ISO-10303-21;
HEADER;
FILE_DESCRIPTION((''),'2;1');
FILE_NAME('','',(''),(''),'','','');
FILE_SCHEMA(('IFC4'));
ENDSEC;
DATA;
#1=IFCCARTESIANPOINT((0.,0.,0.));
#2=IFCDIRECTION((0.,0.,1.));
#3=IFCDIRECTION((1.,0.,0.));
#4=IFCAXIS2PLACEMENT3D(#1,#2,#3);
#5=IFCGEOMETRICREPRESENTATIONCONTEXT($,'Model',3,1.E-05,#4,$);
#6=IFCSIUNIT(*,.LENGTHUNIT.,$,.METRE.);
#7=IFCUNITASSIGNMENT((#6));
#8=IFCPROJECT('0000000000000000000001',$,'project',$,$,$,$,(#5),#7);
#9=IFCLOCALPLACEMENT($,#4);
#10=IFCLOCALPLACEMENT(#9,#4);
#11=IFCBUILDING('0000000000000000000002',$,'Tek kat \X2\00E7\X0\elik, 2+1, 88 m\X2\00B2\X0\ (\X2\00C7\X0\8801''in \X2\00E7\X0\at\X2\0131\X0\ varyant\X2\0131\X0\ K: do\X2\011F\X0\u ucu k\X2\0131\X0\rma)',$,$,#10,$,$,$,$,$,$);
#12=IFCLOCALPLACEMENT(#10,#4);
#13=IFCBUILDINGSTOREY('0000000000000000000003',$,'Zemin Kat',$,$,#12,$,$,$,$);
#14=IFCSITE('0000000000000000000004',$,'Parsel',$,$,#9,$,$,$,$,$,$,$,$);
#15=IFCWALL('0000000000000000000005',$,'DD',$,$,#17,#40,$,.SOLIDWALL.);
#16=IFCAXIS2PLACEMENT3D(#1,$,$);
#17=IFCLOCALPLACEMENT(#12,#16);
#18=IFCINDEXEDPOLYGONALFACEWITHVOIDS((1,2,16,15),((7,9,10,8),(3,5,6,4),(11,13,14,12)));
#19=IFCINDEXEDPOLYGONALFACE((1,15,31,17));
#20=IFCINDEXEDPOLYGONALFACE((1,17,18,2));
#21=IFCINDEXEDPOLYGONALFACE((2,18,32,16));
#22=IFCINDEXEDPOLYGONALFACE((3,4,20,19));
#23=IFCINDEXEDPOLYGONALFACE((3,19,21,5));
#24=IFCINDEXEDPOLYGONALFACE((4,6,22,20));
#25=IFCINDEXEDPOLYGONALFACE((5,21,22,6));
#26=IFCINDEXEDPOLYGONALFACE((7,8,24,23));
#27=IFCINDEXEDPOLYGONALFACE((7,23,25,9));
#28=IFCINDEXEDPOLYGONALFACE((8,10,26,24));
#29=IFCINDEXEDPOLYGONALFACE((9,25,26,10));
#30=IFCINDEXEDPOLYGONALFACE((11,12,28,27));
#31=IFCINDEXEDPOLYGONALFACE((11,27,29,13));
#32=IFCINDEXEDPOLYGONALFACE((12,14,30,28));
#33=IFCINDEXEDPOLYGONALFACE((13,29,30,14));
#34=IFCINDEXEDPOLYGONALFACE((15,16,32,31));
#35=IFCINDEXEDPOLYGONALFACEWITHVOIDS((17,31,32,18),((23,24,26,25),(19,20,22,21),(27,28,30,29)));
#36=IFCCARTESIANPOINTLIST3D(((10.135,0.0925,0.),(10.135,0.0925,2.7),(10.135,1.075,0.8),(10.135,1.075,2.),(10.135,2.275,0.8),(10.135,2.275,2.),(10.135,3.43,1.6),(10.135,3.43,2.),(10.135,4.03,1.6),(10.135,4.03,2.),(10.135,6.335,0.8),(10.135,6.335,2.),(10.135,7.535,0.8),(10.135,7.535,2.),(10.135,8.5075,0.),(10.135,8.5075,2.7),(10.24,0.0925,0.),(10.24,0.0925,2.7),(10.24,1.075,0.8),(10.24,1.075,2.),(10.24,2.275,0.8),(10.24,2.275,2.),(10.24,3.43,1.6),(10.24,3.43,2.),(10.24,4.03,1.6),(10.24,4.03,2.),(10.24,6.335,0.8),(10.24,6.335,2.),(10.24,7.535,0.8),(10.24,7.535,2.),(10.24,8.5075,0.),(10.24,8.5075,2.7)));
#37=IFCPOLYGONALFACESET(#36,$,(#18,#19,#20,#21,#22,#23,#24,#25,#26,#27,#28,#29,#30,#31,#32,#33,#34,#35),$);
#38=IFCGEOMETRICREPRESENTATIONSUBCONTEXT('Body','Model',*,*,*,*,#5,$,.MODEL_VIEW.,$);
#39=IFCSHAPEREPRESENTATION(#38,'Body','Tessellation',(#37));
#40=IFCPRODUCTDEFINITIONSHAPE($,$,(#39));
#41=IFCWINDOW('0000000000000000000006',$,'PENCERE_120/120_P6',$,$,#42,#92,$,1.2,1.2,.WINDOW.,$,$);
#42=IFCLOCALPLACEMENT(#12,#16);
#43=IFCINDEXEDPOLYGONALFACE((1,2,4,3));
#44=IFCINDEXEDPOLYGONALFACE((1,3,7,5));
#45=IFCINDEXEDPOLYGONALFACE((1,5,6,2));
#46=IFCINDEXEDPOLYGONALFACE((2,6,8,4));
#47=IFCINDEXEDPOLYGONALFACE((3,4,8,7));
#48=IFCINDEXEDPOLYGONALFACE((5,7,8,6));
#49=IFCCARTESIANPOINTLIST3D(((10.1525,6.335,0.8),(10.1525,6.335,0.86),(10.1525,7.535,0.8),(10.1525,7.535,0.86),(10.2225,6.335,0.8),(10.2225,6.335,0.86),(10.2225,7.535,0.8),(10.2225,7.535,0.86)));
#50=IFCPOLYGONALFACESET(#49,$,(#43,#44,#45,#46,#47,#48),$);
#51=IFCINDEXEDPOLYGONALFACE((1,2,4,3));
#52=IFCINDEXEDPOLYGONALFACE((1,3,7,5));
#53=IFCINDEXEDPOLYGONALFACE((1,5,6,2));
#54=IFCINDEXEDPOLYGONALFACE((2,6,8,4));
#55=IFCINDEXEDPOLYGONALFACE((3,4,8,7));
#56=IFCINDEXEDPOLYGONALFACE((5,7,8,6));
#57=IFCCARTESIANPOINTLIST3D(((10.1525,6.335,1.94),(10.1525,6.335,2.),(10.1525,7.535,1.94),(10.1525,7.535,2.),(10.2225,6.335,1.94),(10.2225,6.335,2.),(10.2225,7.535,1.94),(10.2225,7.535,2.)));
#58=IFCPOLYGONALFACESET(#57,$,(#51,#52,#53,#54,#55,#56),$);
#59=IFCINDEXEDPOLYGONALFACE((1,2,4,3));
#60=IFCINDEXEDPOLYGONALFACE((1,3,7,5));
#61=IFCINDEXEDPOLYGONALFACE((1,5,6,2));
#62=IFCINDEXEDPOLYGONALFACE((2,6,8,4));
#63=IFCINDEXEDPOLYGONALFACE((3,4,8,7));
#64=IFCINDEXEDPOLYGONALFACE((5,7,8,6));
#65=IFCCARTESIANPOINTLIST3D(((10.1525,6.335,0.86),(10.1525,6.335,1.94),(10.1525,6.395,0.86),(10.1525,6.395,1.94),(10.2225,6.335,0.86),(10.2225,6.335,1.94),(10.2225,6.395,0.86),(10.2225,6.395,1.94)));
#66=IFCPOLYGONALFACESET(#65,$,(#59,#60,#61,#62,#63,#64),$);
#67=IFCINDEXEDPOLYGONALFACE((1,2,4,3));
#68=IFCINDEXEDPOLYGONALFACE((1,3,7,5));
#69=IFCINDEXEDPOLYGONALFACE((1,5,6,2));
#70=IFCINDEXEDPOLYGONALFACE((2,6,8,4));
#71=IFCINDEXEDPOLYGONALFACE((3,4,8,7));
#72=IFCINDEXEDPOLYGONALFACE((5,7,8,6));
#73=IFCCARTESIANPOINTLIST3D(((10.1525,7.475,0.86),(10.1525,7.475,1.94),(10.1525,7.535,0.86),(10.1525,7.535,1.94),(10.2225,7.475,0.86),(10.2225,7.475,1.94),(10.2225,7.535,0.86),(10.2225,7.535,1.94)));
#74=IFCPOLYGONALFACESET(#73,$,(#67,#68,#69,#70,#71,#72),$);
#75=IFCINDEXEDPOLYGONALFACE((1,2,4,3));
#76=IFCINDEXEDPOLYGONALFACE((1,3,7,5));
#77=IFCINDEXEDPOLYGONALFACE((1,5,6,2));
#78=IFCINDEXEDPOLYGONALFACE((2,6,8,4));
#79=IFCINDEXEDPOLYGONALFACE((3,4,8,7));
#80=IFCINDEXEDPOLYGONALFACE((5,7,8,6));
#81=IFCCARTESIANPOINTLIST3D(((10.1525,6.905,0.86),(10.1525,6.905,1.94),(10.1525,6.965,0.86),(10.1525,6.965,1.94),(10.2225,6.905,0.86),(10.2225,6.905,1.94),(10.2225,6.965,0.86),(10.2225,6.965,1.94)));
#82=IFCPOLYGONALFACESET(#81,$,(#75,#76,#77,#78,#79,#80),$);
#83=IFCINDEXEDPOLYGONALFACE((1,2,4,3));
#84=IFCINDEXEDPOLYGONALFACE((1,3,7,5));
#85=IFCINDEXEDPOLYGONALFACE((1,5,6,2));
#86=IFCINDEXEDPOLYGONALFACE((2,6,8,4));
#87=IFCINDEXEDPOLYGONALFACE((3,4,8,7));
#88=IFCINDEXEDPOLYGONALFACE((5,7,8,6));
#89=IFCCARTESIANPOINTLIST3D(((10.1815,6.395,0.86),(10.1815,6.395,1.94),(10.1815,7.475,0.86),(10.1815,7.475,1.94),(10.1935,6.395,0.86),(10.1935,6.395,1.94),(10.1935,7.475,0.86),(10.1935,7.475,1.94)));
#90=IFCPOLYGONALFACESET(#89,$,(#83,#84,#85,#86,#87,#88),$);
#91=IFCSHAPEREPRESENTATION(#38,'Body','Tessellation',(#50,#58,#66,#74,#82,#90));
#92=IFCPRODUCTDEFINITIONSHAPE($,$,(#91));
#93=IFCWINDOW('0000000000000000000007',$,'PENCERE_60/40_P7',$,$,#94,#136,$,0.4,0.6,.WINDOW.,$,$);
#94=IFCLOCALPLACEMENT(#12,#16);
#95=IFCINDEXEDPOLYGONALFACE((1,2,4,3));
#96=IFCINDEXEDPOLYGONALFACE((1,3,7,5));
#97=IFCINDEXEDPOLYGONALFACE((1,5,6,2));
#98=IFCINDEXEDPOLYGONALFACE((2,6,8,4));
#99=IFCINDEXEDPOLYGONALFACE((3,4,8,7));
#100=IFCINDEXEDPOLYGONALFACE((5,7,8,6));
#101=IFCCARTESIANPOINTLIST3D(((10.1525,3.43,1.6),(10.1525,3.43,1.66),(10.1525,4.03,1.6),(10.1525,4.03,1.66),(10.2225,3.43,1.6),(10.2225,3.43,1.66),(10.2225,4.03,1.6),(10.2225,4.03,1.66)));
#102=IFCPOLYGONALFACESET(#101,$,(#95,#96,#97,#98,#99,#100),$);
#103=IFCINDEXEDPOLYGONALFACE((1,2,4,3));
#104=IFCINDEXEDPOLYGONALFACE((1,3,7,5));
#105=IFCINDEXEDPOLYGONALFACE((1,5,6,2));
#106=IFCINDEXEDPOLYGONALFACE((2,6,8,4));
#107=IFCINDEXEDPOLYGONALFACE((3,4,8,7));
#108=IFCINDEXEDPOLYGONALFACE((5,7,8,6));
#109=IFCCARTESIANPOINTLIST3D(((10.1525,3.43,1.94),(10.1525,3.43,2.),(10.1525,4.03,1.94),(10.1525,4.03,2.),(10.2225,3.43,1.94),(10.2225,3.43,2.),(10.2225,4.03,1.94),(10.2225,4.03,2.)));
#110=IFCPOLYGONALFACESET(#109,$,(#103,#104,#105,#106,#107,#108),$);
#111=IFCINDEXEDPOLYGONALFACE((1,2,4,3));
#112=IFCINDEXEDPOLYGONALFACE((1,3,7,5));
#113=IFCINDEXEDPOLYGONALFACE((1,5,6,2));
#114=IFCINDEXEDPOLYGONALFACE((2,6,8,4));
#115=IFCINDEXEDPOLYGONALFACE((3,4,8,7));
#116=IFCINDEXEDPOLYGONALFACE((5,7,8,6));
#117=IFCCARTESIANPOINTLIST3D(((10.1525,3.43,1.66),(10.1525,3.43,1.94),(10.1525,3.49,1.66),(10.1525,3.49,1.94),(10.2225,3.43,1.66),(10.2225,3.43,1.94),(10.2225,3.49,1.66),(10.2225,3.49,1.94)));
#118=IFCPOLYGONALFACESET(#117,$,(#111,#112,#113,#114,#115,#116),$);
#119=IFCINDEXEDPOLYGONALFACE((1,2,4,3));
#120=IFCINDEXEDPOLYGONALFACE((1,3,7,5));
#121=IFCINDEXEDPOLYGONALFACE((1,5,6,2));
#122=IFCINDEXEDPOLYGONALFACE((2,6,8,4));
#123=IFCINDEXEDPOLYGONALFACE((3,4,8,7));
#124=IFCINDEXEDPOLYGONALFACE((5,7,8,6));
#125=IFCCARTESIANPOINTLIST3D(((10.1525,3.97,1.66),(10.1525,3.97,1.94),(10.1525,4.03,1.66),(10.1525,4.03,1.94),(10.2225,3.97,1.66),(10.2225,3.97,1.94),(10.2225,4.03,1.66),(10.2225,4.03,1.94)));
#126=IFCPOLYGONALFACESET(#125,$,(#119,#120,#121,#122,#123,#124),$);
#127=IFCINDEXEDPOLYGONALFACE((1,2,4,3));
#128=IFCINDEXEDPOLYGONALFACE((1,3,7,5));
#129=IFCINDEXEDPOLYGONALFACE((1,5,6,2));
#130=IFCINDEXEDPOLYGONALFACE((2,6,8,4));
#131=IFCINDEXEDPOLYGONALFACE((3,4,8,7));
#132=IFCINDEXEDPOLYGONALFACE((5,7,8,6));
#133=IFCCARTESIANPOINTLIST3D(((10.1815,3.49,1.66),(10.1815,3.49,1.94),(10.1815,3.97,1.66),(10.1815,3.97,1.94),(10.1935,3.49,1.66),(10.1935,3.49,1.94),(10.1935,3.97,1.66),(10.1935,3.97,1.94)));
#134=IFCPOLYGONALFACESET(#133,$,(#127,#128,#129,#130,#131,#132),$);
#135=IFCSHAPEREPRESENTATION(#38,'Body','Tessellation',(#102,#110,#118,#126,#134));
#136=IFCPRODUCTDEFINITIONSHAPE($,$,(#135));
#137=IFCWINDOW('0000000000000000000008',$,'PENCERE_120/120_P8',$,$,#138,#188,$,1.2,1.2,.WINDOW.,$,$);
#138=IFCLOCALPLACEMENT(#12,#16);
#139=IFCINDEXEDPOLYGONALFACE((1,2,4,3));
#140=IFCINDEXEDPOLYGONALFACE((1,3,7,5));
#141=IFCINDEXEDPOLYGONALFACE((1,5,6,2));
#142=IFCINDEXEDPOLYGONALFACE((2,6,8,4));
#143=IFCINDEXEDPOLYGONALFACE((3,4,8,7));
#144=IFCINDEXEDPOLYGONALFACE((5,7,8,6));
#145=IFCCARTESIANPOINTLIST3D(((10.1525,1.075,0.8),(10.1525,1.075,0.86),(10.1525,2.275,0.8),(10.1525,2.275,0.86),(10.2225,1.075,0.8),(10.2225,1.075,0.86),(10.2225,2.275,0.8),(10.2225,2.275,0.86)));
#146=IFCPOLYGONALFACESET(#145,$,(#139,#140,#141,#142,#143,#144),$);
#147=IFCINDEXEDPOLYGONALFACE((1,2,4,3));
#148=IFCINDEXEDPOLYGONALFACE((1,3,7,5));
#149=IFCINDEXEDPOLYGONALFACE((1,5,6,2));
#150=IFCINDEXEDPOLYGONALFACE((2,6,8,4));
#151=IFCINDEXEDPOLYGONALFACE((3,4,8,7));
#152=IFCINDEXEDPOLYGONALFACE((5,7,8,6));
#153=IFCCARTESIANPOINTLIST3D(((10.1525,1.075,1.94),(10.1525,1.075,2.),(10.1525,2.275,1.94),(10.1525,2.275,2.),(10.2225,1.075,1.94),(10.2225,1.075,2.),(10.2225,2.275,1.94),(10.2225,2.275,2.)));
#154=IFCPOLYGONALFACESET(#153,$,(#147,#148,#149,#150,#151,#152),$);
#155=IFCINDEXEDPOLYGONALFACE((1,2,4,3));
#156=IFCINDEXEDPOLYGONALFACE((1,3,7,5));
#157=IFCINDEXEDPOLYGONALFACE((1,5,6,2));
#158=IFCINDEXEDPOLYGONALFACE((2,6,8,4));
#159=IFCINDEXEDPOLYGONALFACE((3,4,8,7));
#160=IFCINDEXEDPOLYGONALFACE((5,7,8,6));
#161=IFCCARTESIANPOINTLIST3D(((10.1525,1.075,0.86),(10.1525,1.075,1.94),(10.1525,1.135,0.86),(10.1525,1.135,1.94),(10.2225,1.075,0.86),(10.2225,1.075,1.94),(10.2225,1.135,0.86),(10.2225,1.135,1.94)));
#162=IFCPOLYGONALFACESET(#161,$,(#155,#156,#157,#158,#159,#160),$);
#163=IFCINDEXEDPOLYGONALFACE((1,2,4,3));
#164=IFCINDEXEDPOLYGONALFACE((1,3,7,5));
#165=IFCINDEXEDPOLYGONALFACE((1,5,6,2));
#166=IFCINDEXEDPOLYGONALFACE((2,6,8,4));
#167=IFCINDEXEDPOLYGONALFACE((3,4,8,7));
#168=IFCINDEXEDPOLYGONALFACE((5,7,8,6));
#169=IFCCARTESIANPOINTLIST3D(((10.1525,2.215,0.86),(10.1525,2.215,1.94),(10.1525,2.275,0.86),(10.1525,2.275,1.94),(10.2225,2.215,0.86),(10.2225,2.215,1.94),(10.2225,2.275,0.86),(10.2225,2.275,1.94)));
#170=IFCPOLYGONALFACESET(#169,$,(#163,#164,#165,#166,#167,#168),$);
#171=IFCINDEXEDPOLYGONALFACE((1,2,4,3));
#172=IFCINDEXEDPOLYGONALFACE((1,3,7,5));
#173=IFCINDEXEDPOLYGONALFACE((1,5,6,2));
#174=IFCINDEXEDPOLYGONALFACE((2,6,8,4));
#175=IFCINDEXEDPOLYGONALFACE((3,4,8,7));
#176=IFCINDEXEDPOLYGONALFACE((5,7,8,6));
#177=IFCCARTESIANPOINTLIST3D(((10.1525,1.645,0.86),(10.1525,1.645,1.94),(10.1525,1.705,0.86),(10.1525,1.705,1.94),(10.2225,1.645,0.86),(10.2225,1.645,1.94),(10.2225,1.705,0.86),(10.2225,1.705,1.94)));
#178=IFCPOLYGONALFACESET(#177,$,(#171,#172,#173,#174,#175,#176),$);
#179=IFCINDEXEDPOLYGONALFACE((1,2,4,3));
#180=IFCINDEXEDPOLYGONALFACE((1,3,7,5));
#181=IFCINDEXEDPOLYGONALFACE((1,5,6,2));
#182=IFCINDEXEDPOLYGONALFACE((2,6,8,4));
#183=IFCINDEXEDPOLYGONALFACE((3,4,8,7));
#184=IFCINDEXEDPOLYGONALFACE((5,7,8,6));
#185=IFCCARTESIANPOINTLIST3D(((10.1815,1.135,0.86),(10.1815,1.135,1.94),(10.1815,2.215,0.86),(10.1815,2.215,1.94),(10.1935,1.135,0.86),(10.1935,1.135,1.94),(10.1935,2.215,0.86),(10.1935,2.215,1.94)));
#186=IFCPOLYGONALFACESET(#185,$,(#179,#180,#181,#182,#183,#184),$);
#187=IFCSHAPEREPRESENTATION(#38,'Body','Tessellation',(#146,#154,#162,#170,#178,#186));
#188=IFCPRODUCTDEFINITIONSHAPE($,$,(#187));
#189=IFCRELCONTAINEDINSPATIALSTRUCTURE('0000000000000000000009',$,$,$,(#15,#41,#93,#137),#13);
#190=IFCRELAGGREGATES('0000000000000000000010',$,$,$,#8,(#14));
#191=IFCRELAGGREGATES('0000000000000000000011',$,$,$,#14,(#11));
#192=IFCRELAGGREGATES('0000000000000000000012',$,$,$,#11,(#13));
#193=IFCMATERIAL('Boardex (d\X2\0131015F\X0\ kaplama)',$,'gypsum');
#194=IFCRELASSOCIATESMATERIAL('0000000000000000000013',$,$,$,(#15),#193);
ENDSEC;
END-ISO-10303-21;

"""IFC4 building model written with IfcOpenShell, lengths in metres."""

from ifc_helpers import new_model, si_unit, frame, origin_with_axes, place, context, subcontext, project, spatial, line, indexed_curve, outline, extrude, material, element, fill, save


model = new_model("IFC4")

# Units and contexts
model_context = context("Model", 3, precision=1e-05, world=origin_with_axes())
body_context = subcontext(model_context, "Body", "Model", "MODEL_VIEW")
ifc_project = project(units=[si_unit("LENGTHUNIT", "METRE")], contexts=[model_context])

# Site, building, storey
site_placement = place(None, origin_with_axes())
site = spatial("IfcSite", under=ifc_project, at=site_placement, Name="Parsel")
building_placement = place(site_placement, origin_with_axes())
building = spatial("IfcBuilding", under=site, at=building_placement, Name="Tek kat çelik, 2+1, 88 m² (Ç8801'in çatı varyantı K: doğu ucu kırma)")
storey_placement = place(building_placement, origin_with_axes())
storey = spatial("IfcBuildingStorey", under=building, at=storey_placement, Name="Zemin Kat")

# Wall, openings, windows
ifc_material_1 = material(Name="Boardex (dış kaplama)", Category="gypsum")
wall_1_placement = place(storey_placement, origin_with_axes())
wall_1 = element("IfcWall", 1, at=wall_1_placement, inside=storey, material=ifc_material_1, Name="DD", PredefinedType="SOLIDWALL", context=body_context, shape_type="SweptSolid", body=[
    extrude(outline(indexed_curve([(0.0, 0.0), (0.105, 0.0), (0.105, 8.415), (0.0, 8.415)], segments=[line(1, 2, 3, 4, 1)])), frame((10.135, 0.0925, 0.0), z_axis=(0.0, 0.0, 1.0), x_axis=(1.0, 0.0, 0.0)), (0.0, 0.0, 1.0), 2.7),
])
opening_1_placement = place(wall_1_placement, origin_with_axes())
opening_1 = element("IfcOpeningElement", 2, at=opening_1_placement, cuts=wall_1, PredefinedType="OPENING", context=body_context, shape_type="SweptSolid", body=[
    extrude(outline(indexed_curve([(0.0, 0.0), (0.145, 0.0), (0.145, 1.2), (0.0, 1.2)], segments=[line(1, 2, 3, 4, 1)])), frame((10.115, 6.335, 0.8), z_axis=(0.0, 0.0, 1.0), x_axis=(1.0, 0.0, 0.0)), (0.0, 0.0, 1.0), 1.2),
])
opening_2_placement = place(wall_1_placement, origin_with_axes())
opening_2 = element("IfcOpeningElement", 3, at=opening_2_placement, cuts=wall_1, PredefinedType="OPENING", context=body_context, shape_type="SweptSolid", body=[
    extrude(outline(indexed_curve([(0.0, 0.0), (0.145, 0.0), (0.145, 0.6), (0.0, 0.6)], segments=[line(1, 2, 3, 4, 1)])), frame((10.115, 3.43, 1.6), z_axis=(0.0, 0.0, 1.0), x_axis=(1.0, 0.0, 0.0)), (0.0, 0.0, 1.0), 0.4),
])
opening_3_placement = place(wall_1_placement, origin_with_axes())
opening_3 = element("IfcOpeningElement", 4, at=opening_3_placement, cuts=wall_1, PredefinedType="OPENING", context=body_context, shape_type="SweptSolid", body=[
    extrude(outline(indexed_curve([(0.0, 0.0), (0.145, 0.0), (0.145, 1.2), (0.0, 1.2)], segments=[line(1, 2, 3, 4, 1)])), frame((10.115, 1.075, 0.8), z_axis=(0.0, 0.0, 1.0), x_axis=(1.0, 0.0, 0.0)), (0.0, 0.0, 1.0), 1.2),
])
window_1_placement = place(storey_placement, origin_with_axes())
window_1 = element("IfcWindow", 5, at=window_1_placement, inside=storey, Name="PENCERE_120/120_P6", OverallHeight=1.2, OverallWidth=1.2, PredefinedType="WINDOW", context=body_context, shape_type="SweptSolid", body=[
    extrude(outline(indexed_curve([(0.0, 0.0), (0.07, 0.0), (0.07, 1.2), (0.0, 1.2)], segments=[line(1, 2, 3, 4, 1)])), frame((10.1525, 6.335, 0.8), z_axis=(0.0, 0.0, 1.0), x_axis=(1.0, 0.0, 0.0)), (0.0, 0.0, 1.0), 0.06),
    extrude(outline(indexed_curve([(0.0, 0.0), (0.07, 0.0), (0.07, 1.2), (0.0, 1.2)], segments=[line(1, 2, 3, 4, 1)])), frame((10.1525, 6.335, 1.94), z_axis=(0.0, 0.0, 1.0), x_axis=(1.0, 0.0, 0.0)), (0.0, 0.0, 1.0), 0.06),
    extrude(outline(indexed_curve([(0.0, 0.0), (0.07, 0.0), (0.07, 0.06), (0.0, 0.06)], segments=[line(1, 2, 3, 4, 1)])), frame((10.1525, 6.335, 0.86), z_axis=(0.0, 0.0, 1.0), x_axis=(1.0, 0.0, 0.0)), (0.0, 0.0, 1.0), 1.08),
    extrude(outline(indexed_curve([(0.0, 0.0), (0.07, 0.0), (0.07, 0.06), (0.0, 0.06)], segments=[line(1, 2, 3, 4, 1)])), frame((10.1525, 7.475, 0.86), z_axis=(0.0, 0.0, 1.0), x_axis=(1.0, 0.0, 0.0)), (0.0, 0.0, 1.0), 1.08),
    extrude(outline(indexed_curve([(0.0, 0.0), (0.07, 0.0), (0.07, 0.06), (0.0, 0.06)], segments=[line(1, 2, 3, 4, 1)])), frame((10.1525, 6.905, 0.86), z_axis=(0.0, 0.0, 1.0), x_axis=(1.0, 0.0, 0.0)), (0.0, 0.0, 1.0), 1.08),
    extrude(outline(indexed_curve([(0.0, 0.0), (0.012, 0.0), (0.012, 1.08), (0.0, 1.08)], segments=[line(1, 2, 3, 4, 1)])), frame((10.1815, 6.395, 0.86), z_axis=(0.0, 0.0, 1.0), x_axis=(1.0, 0.0, 0.0)), (0.0, 0.0, 1.0), 1.08),
])
fill(opening_1, window_1)
window_2_placement = place(storey_placement, origin_with_axes())
window_2 = element("IfcWindow", 6, at=window_2_placement, inside=storey, Name="PENCERE_60/40_P7", OverallHeight=0.4, OverallWidth=0.6, PredefinedType="WINDOW", context=body_context, shape_type="SweptSolid", body=[
    extrude(outline(indexed_curve([(0.0, 0.0), (0.07, 0.0), (0.07, 0.6), (0.0, 0.6)], segments=[line(1, 2, 3, 4, 1)])), frame((10.1525, 3.43, 1.6), z_axis=(0.0, 0.0, 1.0), x_axis=(1.0, 0.0, 0.0)), (0.0, 0.0, 1.0), 0.06),
    extrude(outline(indexed_curve([(0.0, 0.0), (0.07, 0.0), (0.07, 0.6), (0.0, 0.6)], segments=[line(1, 2, 3, 4, 1)])), frame((10.1525, 3.43, 1.94), z_axis=(0.0, 0.0, 1.0), x_axis=(1.0, 0.0, 0.0)), (0.0, 0.0, 1.0), 0.06),
    extrude(outline(indexed_curve([(0.0, 0.0), (0.07, 0.0), (0.07, 0.06), (0.0, 0.06)], segments=[line(1, 2, 3, 4, 1)])), frame((10.1525, 3.43, 1.66), z_axis=(0.0, 0.0, 1.0), x_axis=(1.0, 0.0, 0.0)), (0.0, 0.0, 1.0), 0.28),
    extrude(outline(indexed_curve([(0.0, 0.0), (0.07, 0.0), (0.07, 0.06), (0.0, 0.06)], segments=[line(1, 2, 3, 4, 1)])), frame((10.1525, 3.97, 1.66), z_axis=(0.0, 0.0, 1.0), x_axis=(1.0, 0.0, 0.0)), (0.0, 0.0, 1.0), 0.28),
    extrude(outline(indexed_curve([(0.0, 0.0), (0.012, 0.0), (0.012, 0.48), (0.0, 0.48)], segments=[line(1, 2, 3, 4, 1)])), frame((10.1815, 3.49, 1.66), z_axis=(0.0, 0.0, 1.0), x_axis=(1.0, 0.0, 0.0)), (0.0, 0.0, 1.0), 0.28),
])
fill(opening_2, window_2)
window_3_placement = place(storey_placement, origin_with_axes())
window_3 = element("IfcWindow", 7, at=window_3_placement, inside=storey, Name="PENCERE_120/120_P8", OverallHeight=1.2, OverallWidth=1.2, PredefinedType="WINDOW", context=body_context, shape_type="SweptSolid", body=[
    extrude(outline(indexed_curve([(0.0, 0.0), (0.07, 0.0), (0.07, 1.2), (0.0, 1.2)], segments=[line(1, 2, 3, 4, 1)])), frame((10.1525, 1.075, 0.8), z_axis=(0.0, 0.0, 1.0), x_axis=(1.0, 0.0, 0.0)), (0.0, 0.0, 1.0), 0.06),
    extrude(outline(indexed_curve([(0.0, 0.0), (0.07, 0.0), (0.07, 1.2), (0.0, 1.2)], segments=[line(1, 2, 3, 4, 1)])), frame((10.1525, 1.075, 1.94), z_axis=(0.0, 0.0, 1.0), x_axis=(1.0, 0.0, 0.0)), (0.0, 0.0, 1.0), 0.06),
    extrude(outline(indexed_curve([(0.0, 0.0), (0.07, 0.0), (0.07, 0.06), (0.0, 0.06)], segments=[line(1, 2, 3, 4, 1)])), frame((10.1525, 1.075, 0.86), z_axis=(0.0, 0.0, 1.0), x_axis=(1.0, 0.0, 0.0)), (0.0, 0.0, 1.0), 1.08),
    extrude(outline(indexed_curve([(0.0, 0.0), (0.07, 0.0), (0.07, 0.06), (0.0, 0.06)], segments=[line(1, 2, 3, 4, 1)])), frame((10.1525, 2.215, 0.86), z_axis=(0.0, 0.0, 1.0), x_axis=(1.0, 0.0, 0.0)), (0.0, 0.0, 1.0), 1.08),
    extrude(outline(indexed_curve([(0.0, 0.0), (0.07, 0.0), (0.07, 0.06), (0.0, 0.06)], segments=[line(1, 2, 3, 4, 1)])), frame((10.1525, 1.645, 0.86), z_axis=(0.0, 0.0, 1.0), x_axis=(1.0, 0.0, 0.0)), (0.0, 0.0, 1.0), 1.08),
    extrude(outline(indexed_curve([(0.0, 0.0), (0.012, 0.0), (0.012, 1.08), (0.0, 1.08)], segments=[line(1, 2, 3, 4, 1)])), frame((10.1815, 1.135, 0.86), z_axis=(0.0, 0.0, 1.0), x_axis=(1.0, 0.0, 0.0)), (0.0, 0.0, 1.0), 1.08),
])
fill(opening_3, window_3)

save(model, "model.ifc")
